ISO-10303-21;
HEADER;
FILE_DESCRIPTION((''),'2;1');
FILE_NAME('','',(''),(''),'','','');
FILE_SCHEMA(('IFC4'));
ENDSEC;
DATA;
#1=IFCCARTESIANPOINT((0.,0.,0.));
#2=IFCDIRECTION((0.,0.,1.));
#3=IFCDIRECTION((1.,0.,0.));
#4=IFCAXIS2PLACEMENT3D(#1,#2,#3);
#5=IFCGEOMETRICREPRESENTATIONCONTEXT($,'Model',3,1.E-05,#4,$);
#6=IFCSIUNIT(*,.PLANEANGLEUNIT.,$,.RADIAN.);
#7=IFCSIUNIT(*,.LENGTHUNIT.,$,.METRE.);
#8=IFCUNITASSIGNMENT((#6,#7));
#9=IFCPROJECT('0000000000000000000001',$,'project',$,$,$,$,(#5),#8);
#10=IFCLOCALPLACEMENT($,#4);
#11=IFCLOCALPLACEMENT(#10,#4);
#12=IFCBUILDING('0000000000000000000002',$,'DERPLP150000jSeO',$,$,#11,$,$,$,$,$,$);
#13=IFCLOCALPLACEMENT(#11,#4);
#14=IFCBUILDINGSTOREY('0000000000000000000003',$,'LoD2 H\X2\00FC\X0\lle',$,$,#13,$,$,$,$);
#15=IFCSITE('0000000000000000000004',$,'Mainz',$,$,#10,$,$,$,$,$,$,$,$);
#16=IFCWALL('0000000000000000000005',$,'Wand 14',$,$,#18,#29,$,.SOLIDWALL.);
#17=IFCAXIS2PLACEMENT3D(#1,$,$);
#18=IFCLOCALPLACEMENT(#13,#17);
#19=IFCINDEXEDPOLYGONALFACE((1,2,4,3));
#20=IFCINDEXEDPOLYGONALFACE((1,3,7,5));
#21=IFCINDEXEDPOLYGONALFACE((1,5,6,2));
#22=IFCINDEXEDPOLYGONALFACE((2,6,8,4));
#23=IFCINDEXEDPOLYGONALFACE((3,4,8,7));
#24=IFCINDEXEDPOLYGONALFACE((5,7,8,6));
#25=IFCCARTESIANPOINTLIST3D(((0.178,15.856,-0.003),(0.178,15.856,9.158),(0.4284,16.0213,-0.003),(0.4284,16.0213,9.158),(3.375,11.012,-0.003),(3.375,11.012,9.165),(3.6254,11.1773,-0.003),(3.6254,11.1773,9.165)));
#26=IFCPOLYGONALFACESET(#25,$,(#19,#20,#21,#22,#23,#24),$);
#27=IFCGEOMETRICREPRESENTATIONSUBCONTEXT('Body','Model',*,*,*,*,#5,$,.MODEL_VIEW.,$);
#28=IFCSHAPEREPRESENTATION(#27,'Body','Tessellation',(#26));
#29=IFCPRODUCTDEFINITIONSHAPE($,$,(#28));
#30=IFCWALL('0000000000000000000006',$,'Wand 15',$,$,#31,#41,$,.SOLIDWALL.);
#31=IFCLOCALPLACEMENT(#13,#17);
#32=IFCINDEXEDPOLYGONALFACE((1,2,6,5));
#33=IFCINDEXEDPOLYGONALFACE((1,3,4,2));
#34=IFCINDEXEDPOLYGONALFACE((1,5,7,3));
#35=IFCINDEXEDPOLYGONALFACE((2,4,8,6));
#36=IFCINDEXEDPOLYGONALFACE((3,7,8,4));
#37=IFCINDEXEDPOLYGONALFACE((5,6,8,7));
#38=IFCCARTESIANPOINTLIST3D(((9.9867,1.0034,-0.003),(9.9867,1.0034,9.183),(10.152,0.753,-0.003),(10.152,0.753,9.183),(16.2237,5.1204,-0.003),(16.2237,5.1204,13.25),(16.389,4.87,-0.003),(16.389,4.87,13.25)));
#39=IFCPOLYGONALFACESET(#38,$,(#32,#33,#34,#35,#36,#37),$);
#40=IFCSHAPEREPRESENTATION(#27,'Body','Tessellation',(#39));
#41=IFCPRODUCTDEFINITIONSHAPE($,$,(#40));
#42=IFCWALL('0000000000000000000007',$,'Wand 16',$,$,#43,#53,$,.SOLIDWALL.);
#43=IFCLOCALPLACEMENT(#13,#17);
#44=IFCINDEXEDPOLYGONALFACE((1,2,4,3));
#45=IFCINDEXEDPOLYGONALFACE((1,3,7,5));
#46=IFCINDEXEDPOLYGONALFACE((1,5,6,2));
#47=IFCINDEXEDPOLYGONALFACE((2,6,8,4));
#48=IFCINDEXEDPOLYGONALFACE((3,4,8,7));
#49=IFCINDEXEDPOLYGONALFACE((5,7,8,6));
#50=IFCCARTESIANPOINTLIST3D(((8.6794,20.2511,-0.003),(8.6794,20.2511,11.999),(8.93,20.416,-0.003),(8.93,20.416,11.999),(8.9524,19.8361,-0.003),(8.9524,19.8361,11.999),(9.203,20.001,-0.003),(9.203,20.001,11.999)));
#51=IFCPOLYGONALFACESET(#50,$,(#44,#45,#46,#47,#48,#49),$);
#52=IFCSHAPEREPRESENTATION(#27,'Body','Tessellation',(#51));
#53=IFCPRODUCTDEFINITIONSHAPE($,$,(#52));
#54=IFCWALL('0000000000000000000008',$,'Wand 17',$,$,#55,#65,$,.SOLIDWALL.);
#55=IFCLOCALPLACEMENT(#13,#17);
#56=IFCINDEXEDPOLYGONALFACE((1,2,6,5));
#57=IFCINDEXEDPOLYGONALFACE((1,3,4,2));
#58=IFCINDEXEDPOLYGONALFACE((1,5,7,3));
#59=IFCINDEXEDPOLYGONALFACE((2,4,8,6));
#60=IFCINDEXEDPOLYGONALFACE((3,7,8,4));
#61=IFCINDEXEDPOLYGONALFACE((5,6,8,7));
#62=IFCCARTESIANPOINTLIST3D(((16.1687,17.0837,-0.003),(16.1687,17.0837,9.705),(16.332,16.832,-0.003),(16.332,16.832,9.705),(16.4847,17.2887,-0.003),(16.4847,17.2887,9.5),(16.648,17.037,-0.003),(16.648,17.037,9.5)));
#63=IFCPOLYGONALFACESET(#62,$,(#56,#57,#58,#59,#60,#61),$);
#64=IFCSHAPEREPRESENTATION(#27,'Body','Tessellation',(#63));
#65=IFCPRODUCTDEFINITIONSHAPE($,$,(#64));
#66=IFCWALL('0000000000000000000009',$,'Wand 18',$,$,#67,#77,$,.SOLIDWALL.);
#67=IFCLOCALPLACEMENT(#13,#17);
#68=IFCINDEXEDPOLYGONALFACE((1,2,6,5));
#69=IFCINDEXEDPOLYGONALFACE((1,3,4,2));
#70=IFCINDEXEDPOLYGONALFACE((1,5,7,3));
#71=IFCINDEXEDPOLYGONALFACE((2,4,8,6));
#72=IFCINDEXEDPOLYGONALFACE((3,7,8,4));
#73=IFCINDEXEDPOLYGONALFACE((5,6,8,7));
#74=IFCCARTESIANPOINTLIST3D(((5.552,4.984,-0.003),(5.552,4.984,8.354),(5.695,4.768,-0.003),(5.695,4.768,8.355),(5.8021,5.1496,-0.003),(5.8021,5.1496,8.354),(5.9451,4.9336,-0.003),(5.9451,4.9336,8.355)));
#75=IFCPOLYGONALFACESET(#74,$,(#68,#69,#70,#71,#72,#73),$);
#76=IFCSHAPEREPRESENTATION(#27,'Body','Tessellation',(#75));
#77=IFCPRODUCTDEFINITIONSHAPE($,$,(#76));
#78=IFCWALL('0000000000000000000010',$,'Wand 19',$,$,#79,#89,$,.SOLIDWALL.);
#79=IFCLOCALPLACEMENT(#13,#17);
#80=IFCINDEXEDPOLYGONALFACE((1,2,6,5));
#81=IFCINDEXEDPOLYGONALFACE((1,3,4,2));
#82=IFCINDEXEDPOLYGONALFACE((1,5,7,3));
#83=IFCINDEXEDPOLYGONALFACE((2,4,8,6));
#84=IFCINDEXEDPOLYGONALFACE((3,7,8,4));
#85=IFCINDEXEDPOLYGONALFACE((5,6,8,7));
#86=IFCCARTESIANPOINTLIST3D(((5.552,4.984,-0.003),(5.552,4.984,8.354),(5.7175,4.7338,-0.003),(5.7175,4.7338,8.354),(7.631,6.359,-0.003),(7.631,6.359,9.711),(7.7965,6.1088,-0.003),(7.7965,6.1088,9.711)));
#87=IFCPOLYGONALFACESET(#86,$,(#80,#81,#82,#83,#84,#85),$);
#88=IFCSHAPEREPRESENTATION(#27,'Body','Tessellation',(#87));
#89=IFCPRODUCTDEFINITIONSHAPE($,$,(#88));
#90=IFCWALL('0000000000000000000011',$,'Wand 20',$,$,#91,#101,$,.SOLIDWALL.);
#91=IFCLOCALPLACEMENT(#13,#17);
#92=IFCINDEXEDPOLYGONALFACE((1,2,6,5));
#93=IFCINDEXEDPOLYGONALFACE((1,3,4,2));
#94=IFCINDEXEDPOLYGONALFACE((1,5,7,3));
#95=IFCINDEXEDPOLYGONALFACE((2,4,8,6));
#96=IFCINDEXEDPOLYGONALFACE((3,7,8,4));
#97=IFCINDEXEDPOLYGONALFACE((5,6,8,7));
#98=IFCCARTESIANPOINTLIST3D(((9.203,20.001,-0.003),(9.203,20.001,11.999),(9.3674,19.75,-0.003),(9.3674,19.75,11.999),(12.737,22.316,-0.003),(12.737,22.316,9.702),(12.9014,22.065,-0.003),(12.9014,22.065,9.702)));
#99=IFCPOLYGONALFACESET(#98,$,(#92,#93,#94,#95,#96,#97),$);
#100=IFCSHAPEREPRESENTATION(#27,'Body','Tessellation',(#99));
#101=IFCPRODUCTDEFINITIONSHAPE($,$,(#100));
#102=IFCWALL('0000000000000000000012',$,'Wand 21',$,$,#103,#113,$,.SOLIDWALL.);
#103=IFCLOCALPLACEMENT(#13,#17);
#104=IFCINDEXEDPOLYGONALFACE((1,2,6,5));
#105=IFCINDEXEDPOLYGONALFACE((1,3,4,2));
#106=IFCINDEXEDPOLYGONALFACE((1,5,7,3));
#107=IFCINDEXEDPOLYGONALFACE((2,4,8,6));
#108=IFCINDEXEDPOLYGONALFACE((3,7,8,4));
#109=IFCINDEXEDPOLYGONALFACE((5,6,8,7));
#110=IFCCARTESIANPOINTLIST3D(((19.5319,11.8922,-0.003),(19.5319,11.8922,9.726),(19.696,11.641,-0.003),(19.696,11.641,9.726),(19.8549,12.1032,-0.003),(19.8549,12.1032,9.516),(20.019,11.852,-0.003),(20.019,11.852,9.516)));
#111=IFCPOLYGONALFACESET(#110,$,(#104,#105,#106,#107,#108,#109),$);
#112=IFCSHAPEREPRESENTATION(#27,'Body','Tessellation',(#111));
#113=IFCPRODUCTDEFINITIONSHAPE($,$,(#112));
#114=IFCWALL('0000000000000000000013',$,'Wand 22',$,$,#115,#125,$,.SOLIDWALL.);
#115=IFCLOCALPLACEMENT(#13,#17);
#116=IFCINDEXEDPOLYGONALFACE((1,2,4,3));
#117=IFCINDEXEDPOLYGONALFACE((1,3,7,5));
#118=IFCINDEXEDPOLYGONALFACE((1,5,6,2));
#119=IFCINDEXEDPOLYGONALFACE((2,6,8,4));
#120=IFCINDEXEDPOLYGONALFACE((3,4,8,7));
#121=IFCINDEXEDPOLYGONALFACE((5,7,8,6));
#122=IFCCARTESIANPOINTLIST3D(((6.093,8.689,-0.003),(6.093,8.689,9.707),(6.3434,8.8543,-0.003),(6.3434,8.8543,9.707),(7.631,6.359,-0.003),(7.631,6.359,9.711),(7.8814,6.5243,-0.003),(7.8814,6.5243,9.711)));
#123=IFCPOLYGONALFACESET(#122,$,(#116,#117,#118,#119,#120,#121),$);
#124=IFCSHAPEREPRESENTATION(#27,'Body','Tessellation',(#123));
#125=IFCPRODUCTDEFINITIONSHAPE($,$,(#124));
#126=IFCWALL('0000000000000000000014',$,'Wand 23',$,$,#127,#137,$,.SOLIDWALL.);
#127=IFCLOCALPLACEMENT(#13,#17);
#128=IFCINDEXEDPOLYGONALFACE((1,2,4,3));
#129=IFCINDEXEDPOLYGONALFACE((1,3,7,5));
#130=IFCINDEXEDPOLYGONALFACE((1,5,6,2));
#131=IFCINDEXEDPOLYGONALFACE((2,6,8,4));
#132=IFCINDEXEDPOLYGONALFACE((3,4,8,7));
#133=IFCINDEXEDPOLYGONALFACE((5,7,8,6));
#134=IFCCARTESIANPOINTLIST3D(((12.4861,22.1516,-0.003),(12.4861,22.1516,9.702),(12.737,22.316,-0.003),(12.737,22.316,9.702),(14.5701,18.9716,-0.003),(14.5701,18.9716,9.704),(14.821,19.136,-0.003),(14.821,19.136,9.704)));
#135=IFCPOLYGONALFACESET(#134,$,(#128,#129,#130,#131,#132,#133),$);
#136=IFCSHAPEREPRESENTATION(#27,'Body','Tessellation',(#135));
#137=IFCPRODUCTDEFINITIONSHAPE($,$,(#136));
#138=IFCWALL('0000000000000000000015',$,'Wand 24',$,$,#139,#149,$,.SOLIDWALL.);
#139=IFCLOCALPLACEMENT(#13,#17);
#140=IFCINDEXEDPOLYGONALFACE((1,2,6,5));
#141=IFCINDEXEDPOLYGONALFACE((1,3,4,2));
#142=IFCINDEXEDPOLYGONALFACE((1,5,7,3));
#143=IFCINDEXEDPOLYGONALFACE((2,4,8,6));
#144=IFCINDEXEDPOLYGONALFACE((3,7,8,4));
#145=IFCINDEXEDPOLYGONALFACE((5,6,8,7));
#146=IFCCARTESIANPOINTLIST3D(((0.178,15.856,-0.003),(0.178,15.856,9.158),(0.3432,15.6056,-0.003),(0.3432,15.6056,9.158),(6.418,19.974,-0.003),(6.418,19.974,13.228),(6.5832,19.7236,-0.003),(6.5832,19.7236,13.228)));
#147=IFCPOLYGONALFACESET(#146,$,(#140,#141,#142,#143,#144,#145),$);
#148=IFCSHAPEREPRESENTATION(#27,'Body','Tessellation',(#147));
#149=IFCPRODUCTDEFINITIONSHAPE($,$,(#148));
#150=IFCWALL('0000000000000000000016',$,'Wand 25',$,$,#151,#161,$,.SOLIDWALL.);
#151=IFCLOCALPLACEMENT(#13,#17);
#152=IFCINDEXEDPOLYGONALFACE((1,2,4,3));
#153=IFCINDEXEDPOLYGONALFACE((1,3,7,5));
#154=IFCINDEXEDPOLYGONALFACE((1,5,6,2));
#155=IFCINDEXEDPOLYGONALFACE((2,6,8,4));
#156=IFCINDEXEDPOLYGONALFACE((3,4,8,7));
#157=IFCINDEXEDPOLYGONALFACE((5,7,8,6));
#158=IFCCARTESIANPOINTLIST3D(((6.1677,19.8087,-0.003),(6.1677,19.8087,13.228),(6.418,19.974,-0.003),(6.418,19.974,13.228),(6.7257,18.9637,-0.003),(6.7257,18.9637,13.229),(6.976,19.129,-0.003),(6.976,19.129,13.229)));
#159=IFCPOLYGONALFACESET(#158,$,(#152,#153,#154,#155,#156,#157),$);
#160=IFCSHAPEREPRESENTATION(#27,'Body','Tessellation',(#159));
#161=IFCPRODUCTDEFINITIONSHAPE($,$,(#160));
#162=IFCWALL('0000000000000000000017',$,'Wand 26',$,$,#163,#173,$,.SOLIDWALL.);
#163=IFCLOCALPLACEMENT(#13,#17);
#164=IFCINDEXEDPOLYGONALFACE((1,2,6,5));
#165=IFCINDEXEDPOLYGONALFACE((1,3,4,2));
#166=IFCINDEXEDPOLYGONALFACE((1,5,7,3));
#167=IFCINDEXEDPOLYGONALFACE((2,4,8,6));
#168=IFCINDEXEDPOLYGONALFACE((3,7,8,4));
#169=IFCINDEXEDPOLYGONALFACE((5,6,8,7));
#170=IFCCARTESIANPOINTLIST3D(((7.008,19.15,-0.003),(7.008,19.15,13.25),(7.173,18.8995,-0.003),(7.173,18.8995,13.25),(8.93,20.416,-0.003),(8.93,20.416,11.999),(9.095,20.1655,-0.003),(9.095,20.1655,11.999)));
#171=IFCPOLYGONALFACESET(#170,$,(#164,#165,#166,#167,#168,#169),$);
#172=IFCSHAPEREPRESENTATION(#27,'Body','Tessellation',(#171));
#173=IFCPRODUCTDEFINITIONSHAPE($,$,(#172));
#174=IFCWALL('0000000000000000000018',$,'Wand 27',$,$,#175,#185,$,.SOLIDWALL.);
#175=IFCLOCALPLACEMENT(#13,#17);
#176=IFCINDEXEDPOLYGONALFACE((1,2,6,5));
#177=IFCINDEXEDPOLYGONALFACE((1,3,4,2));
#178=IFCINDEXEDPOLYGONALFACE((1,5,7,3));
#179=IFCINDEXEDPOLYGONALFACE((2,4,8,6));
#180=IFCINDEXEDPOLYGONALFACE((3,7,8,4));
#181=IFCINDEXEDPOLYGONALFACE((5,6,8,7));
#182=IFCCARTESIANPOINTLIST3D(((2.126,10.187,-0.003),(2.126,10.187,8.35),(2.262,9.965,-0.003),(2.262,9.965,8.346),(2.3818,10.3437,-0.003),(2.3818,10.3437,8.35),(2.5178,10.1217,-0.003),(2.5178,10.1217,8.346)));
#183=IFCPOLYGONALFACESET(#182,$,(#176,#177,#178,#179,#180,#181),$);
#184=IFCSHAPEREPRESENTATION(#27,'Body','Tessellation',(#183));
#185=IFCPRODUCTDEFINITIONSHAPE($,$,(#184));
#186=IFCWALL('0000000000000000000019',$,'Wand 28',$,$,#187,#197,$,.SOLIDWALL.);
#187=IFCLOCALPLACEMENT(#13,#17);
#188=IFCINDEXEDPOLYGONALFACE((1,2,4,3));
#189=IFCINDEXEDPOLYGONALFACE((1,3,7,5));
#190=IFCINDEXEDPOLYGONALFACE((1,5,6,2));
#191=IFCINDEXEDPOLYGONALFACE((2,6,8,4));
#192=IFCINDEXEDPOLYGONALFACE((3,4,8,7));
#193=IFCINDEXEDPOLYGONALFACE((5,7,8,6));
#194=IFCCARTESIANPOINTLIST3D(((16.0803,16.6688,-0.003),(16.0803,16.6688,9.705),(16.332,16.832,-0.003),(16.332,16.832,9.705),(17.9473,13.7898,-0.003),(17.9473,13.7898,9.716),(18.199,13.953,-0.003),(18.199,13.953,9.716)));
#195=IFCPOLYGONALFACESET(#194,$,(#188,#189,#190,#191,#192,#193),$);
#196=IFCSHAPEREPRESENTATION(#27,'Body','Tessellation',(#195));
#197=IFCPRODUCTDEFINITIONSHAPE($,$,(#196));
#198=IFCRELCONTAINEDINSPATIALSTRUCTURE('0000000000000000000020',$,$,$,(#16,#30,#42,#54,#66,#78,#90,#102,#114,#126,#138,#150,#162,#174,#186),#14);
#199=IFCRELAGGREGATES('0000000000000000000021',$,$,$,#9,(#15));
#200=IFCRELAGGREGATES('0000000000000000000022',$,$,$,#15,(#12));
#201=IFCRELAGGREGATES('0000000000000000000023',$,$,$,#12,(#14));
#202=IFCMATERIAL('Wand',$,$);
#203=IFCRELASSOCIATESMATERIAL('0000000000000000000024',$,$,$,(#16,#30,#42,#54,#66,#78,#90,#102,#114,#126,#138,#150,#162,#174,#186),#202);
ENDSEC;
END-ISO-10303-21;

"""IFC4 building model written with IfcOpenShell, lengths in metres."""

from ifc_helpers import new_model, si_unit, frame, origin_with_axes, place, context, subcontext, project, spatial, polyline, outline, extrude, material, element, save


model = new_model("IFC4")

# Units and contexts
model_context = context("Model", 3, precision=1e-05, world=origin_with_axes())
body_context = subcontext(model_context, "Body", "Model", "MODEL_VIEW")
ifc_project = project(units=[si_unit("PLANEANGLEUNIT", "RADIAN"), si_unit("LENGTHUNIT", "METRE")], contexts=[model_context])

# Site, building, storey
site_placement = place(None, origin_with_axes())
site = spatial("IfcSite", under=ifc_project, at=site_placement, Name="Mainz")
building_placement = place(site_placement, origin_with_axes())
building = spatial("IfcBuilding", under=site, at=building_placement, Name="DERPLP150000jSeO")
storey_placement = place(building_placement, origin_with_axes())
storey = spatial("IfcBuildingStorey", under=building, at=storey_placement, Name="LoD2 Hülle")

# Walls
ifc_material_1 = material(Name="Wand")
wall_1_placement = place(storey_placement, origin_with_axes())
element("IfcWall", 1, at=wall_1_placement, inside=storey, material=ifc_material_1, Name="Wand 14", PredefinedType="SOLIDWALL", context=body_context, shape_type="SweptSolid", body=[
    extrude(outline(polyline([(0.0, 0.0), (5.8039, 0.0), (5.8149, 9.161), (0.0111, 9.168), (0.0, 0.0)])), frame((3.375, 11.012, 9.165), z_axis=(-0.834613, -0.550837, 0.0), x_axis=(-0.550837, 0.834612, -0.001206)), (0.0, 0.0, -1.0), 0.3),
])
wall_2_placement = place(storey_placement, origin_with_axes())
element("IfcWall", 2, at=wall_2_placement, inside=storey, material=ifc_material_1, Name="Wand 15", PredefinedType="SOLIDWALL", context=body_context, shape_type="SweptSolid", body=[
    extrude(outline(polyline([(0.0, 0.0), (8.5083, 0.0), (12.8992, 8.0686), (6.335, 11.6409), (0.0, 0.0)])), frame((16.389, 4.87, 13.25), z_axis=(0.550896, -0.834574, 0.0), x_axis=(-0.733053, -0.483883, -0.478007)), (0.0, 0.0, -1.0), 0.3),
])
wall_3_placement = place(storey_placement, origin_with_axes())
element("IfcWall", 3, at=wall_3_placement, inside=storey, material=ifc_material_1, Name="Wand 16", PredefinedType="SOLIDWALL", context=body_context, shape_type="SweptSolid", body=[
    extrude(outline(polyline([(0.0, 0.0), (0.4967, 0.0), (0.4967, 12.002), (0.0, 12.002), (0.0, 0.0)])), frame((8.93, 20.416, 11.999), z_axis=(0.835441, 0.54958, 0.0), x_axis=(0.54958, -0.835441, 0.0)), (0.0, 0.0, -1.0), 0.3),
])
wall_4_placement = place(storey_placement, origin_with_axes())
element("IfcWall", 4, at=wall_4_placement, inside=storey, material=ifc_material_1, Name="Wand 17", PredefinedType="SOLIDWALL", context=body_context, shape_type="SweptSolid", body=[
    extrude(outline(polyline([(0.0, 0.0), (0.4288, 0.0), (-4.2119, 8.527), (-4.5427, 8.3469), (0.0, 0.0)])), frame((16.648, 17.037, 9.5), z_axis=(0.544242, -0.838929, 0.0), x_axis=(-0.736867, -0.478031, 0.478031)), (0.0, 0.0, -1.0), 0.3),
])
wall_5_placement = place(storey_placement, origin_with_axes())
element("IfcWall", 5, at=wall_5_placement, inside=storey, material=ifc_material_1, Name="Wand 18", PredefinedType="SOLIDWALL", context=body_context, shape_type="SweptSolid", body=[
    extrude(outline(polyline([(0.0, 0.0), (0.259, 0.0), (0.2913, 8.3569), (0.0323, 8.3579), (0.0, 0.0)])), frame((5.695, 4.768, 8.355), z_axis=(-0.833828, -0.552025, 0.0), x_axis=(-0.552021, 0.833821, -0.00386)), (0.0, 0.0, -1.0), 0.3),
])
wall_6_placement = place(storey_placement, origin_with_axes())
element("IfcWall", 6, at=wall_6_placement, inside=storey, material=ifc_material_1, Name="Wand 19", PredefinedType="SOLIDWALL", context=body_context, shape_type="SweptSolid", body=[
    extrude(outline(polyline([(0.0, 0.0), (2.838, 0.0), (-1.8068, 8.5316), (-3.9959, 7.3398), (0.0, 0.0)])), frame((5.552, 4.984, 8.354), z_axis=(-0.551641, 0.834082, 0.0), x_axis=(0.732555, 0.484494, 0.478152)), (0.0, 0.0, -1.0), 0.3),
])
wall_7_placement = place(storey_placement, origin_with_axes())
element("IfcWall", 7, at=wall_7_placement, inside=storey, material=ifc_material_1, Name="Wand 20", PredefinedType="SOLIDWALL", context=body_context, shape_type="SweptSolid", body=[
    extrude(outline(polyline([(0.0, 0.0), (4.8088, 0.0), (9.4445, 8.5262), (5.7329, 10.5443), (0.0, 0.0)])), frame((9.203, 20.001, 11.999), z_axis=(-0.547963, 0.836502, 0.0), x_axis=(0.734902, 0.481409, -0.477666)), (0.0, 0.0, -1.0), 0.3),
])
wall_8_placement = place(storey_placement, origin_with_axes())
element("IfcWall", 8, at=wall_8_placement, inside=storey, material=ifc_material_1, Name="Wand 21", PredefinedType="SOLIDWALL", context=body_context, shape_type="SweptSolid", body=[
    extrude(outline(polyline([(0.0, 0.0), (0.4393, 0.0), (-4.2119, 8.5452), (-4.5508, 8.3607), (0.0, 0.0)])), frame((20.019, 11.852, 9.516), z_axis=(0.5469, -0.837198, 0.0), x_axis=(-0.735326, -0.480353, 0.478076)), (0.0, 0.0, -1.0), 0.3),
])
wall_9_placement = place(storey_placement, origin_with_axes())
element("IfcWall", 9, at=wall_9_placement, inside=storey, material=ifc_material_1, Name="Wand 22", PredefinedType="SOLIDWALL", context=body_context, shape_type="SweptSolid", body=[
    extrude(outline(polyline([(0.0, 0.0), (2.7918, 0.0), (2.8058, 9.71), (0.0139, 9.714), (0.0, 0.0)])), frame((7.631, 6.359, 9.711), z_axis=(-0.834576, -0.550892, 0.0), x_axis=(-0.550892, 0.834576, -0.001433)), (0.0, 0.0, -1.0), 0.3),
])
wall_10_placement = place(storey_placement, origin_with_axes())
element("IfcWall", 10, at=wall_10_placement, inside=storey, material=ifc_material_1, Name="Wand 23", PredefinedType="SOLIDWALL", context=body_context, shape_type="SweptSolid", body=[
    extrude(outline(polyline([(0.0, 0.0), (3.802, 0.0), (3.7969, 9.707), (-0.0051, 9.705), (0.0, 0.0)])), frame((12.737, 22.316, 9.702), z_axis=(0.836395, 0.548128, 0.0), x_axis=(0.548128, -0.836394, 0.000526)), (0.0, 0.0, -1.0), 0.3),
])
wall_11_placement = place(storey_placement, origin_with_axes())
element("IfcWall", 11, at=wall_11_placement, inside=storey, material=ifc_material_1, Name="Wand 24", PredefinedType="SOLIDWALL", context=body_context, shape_type="SweptSolid", body=[
    extrude(outline(polyline([(0.0, 0.0), (8.5124, 0.0), (2.1863, 11.6207), (-4.3801, 8.046), (0.0, 0.0)])), frame((0.178, 15.856, 9.158), z_axis=(-0.550805, 0.834634, 0.0), x_axis=(0.733051, 0.483767, 0.478128)), (0.0, 0.0, -1.0), 0.3),
])
wall_12_placement = place(storey_placement, origin_with_axes())
element("IfcWall", 12, at=wall_12_placement, inside=storey, material=ifc_material_1, Name="Wand 25", PredefinedType="SOLIDWALL", context=body_context, shape_type="SweptSolid", body=[
    extrude(outline(polyline([(0.0, 0.0), (1.0126, 0.0), (0.9995, 13.232), (-0.0131, 13.231), (0.0, 0.0)])), frame((6.418, 19.974, 13.228), z_axis=(0.834473, 0.551049, 0.0), x_axis=(0.551048, -0.834473, 0.000988)), (0.0, 0.0, -1.0), 0.3),
])
wall_13_placement = place(storey_placement, origin_with_axes())
element("IfcWall", 13, at=wall_13_placement, inside=storey, material=ifc_material_1, Name="Wand 26", PredefinedType="SOLIDWALL", context=body_context, shape_type="SweptSolid", body=[
    extrude(outline(polyline([(0.0, 0.0), (2.6195, 0.0), (8.3513, 10.5449), (6.3292, 11.644), (0.0, 0.0)])), frame((7.008, 19.15, 13.25), z_axis=(-0.550079, 0.835112, 0.0), x_axis=(0.733725, 0.483296, -0.47757)), (0.0, 0.0, -1.0), 0.3),
])
wall_14_placement = place(storey_placement, origin_with_axes())
element("IfcWall", 14, at=wall_14_placement, inside=storey, material=ifc_material_1, Name="Wand 27", PredefinedType="SOLIDWALL", context=body_context, shape_type="SweptSolid", body=[
    extrude(outline(polyline([(0.0, 0.0), (0.2604, 0.0), (0.1321, 8.352), (-0.1283, 8.348), (0.0, 0.0)])), frame((2.262, 9.965, 8.346), z_axis=(-0.852712, -0.522382, 0.0), x_axis=(-0.52232, 0.852611, 0.015362)), (0.0, 0.0, -1.0), 0.3),
])
wall_15_placement = place(storey_placement, origin_with_axes())
element("IfcWall", 15, at=wall_15_placement, inside=storey, material=ifc_material_1, Name="Wand 28", PredefinedType="SOLIDWALL", context=body_context, shape_type="SweptSolid", body=[
    extrude(outline(polyline([(0.0, 0.0), (3.4314, 0.0), (3.4002, 9.719), (-0.0311, 9.708), (0.0, 0.0)])), frame((16.332, 16.832, 9.705), z_axis=(0.839022, 0.544097, 0.0), x_axis=(0.544094, -0.839018, 0.003206)), (0.0, 0.0, -1.0), 0.3),
])

save(model, "model.ifc")
